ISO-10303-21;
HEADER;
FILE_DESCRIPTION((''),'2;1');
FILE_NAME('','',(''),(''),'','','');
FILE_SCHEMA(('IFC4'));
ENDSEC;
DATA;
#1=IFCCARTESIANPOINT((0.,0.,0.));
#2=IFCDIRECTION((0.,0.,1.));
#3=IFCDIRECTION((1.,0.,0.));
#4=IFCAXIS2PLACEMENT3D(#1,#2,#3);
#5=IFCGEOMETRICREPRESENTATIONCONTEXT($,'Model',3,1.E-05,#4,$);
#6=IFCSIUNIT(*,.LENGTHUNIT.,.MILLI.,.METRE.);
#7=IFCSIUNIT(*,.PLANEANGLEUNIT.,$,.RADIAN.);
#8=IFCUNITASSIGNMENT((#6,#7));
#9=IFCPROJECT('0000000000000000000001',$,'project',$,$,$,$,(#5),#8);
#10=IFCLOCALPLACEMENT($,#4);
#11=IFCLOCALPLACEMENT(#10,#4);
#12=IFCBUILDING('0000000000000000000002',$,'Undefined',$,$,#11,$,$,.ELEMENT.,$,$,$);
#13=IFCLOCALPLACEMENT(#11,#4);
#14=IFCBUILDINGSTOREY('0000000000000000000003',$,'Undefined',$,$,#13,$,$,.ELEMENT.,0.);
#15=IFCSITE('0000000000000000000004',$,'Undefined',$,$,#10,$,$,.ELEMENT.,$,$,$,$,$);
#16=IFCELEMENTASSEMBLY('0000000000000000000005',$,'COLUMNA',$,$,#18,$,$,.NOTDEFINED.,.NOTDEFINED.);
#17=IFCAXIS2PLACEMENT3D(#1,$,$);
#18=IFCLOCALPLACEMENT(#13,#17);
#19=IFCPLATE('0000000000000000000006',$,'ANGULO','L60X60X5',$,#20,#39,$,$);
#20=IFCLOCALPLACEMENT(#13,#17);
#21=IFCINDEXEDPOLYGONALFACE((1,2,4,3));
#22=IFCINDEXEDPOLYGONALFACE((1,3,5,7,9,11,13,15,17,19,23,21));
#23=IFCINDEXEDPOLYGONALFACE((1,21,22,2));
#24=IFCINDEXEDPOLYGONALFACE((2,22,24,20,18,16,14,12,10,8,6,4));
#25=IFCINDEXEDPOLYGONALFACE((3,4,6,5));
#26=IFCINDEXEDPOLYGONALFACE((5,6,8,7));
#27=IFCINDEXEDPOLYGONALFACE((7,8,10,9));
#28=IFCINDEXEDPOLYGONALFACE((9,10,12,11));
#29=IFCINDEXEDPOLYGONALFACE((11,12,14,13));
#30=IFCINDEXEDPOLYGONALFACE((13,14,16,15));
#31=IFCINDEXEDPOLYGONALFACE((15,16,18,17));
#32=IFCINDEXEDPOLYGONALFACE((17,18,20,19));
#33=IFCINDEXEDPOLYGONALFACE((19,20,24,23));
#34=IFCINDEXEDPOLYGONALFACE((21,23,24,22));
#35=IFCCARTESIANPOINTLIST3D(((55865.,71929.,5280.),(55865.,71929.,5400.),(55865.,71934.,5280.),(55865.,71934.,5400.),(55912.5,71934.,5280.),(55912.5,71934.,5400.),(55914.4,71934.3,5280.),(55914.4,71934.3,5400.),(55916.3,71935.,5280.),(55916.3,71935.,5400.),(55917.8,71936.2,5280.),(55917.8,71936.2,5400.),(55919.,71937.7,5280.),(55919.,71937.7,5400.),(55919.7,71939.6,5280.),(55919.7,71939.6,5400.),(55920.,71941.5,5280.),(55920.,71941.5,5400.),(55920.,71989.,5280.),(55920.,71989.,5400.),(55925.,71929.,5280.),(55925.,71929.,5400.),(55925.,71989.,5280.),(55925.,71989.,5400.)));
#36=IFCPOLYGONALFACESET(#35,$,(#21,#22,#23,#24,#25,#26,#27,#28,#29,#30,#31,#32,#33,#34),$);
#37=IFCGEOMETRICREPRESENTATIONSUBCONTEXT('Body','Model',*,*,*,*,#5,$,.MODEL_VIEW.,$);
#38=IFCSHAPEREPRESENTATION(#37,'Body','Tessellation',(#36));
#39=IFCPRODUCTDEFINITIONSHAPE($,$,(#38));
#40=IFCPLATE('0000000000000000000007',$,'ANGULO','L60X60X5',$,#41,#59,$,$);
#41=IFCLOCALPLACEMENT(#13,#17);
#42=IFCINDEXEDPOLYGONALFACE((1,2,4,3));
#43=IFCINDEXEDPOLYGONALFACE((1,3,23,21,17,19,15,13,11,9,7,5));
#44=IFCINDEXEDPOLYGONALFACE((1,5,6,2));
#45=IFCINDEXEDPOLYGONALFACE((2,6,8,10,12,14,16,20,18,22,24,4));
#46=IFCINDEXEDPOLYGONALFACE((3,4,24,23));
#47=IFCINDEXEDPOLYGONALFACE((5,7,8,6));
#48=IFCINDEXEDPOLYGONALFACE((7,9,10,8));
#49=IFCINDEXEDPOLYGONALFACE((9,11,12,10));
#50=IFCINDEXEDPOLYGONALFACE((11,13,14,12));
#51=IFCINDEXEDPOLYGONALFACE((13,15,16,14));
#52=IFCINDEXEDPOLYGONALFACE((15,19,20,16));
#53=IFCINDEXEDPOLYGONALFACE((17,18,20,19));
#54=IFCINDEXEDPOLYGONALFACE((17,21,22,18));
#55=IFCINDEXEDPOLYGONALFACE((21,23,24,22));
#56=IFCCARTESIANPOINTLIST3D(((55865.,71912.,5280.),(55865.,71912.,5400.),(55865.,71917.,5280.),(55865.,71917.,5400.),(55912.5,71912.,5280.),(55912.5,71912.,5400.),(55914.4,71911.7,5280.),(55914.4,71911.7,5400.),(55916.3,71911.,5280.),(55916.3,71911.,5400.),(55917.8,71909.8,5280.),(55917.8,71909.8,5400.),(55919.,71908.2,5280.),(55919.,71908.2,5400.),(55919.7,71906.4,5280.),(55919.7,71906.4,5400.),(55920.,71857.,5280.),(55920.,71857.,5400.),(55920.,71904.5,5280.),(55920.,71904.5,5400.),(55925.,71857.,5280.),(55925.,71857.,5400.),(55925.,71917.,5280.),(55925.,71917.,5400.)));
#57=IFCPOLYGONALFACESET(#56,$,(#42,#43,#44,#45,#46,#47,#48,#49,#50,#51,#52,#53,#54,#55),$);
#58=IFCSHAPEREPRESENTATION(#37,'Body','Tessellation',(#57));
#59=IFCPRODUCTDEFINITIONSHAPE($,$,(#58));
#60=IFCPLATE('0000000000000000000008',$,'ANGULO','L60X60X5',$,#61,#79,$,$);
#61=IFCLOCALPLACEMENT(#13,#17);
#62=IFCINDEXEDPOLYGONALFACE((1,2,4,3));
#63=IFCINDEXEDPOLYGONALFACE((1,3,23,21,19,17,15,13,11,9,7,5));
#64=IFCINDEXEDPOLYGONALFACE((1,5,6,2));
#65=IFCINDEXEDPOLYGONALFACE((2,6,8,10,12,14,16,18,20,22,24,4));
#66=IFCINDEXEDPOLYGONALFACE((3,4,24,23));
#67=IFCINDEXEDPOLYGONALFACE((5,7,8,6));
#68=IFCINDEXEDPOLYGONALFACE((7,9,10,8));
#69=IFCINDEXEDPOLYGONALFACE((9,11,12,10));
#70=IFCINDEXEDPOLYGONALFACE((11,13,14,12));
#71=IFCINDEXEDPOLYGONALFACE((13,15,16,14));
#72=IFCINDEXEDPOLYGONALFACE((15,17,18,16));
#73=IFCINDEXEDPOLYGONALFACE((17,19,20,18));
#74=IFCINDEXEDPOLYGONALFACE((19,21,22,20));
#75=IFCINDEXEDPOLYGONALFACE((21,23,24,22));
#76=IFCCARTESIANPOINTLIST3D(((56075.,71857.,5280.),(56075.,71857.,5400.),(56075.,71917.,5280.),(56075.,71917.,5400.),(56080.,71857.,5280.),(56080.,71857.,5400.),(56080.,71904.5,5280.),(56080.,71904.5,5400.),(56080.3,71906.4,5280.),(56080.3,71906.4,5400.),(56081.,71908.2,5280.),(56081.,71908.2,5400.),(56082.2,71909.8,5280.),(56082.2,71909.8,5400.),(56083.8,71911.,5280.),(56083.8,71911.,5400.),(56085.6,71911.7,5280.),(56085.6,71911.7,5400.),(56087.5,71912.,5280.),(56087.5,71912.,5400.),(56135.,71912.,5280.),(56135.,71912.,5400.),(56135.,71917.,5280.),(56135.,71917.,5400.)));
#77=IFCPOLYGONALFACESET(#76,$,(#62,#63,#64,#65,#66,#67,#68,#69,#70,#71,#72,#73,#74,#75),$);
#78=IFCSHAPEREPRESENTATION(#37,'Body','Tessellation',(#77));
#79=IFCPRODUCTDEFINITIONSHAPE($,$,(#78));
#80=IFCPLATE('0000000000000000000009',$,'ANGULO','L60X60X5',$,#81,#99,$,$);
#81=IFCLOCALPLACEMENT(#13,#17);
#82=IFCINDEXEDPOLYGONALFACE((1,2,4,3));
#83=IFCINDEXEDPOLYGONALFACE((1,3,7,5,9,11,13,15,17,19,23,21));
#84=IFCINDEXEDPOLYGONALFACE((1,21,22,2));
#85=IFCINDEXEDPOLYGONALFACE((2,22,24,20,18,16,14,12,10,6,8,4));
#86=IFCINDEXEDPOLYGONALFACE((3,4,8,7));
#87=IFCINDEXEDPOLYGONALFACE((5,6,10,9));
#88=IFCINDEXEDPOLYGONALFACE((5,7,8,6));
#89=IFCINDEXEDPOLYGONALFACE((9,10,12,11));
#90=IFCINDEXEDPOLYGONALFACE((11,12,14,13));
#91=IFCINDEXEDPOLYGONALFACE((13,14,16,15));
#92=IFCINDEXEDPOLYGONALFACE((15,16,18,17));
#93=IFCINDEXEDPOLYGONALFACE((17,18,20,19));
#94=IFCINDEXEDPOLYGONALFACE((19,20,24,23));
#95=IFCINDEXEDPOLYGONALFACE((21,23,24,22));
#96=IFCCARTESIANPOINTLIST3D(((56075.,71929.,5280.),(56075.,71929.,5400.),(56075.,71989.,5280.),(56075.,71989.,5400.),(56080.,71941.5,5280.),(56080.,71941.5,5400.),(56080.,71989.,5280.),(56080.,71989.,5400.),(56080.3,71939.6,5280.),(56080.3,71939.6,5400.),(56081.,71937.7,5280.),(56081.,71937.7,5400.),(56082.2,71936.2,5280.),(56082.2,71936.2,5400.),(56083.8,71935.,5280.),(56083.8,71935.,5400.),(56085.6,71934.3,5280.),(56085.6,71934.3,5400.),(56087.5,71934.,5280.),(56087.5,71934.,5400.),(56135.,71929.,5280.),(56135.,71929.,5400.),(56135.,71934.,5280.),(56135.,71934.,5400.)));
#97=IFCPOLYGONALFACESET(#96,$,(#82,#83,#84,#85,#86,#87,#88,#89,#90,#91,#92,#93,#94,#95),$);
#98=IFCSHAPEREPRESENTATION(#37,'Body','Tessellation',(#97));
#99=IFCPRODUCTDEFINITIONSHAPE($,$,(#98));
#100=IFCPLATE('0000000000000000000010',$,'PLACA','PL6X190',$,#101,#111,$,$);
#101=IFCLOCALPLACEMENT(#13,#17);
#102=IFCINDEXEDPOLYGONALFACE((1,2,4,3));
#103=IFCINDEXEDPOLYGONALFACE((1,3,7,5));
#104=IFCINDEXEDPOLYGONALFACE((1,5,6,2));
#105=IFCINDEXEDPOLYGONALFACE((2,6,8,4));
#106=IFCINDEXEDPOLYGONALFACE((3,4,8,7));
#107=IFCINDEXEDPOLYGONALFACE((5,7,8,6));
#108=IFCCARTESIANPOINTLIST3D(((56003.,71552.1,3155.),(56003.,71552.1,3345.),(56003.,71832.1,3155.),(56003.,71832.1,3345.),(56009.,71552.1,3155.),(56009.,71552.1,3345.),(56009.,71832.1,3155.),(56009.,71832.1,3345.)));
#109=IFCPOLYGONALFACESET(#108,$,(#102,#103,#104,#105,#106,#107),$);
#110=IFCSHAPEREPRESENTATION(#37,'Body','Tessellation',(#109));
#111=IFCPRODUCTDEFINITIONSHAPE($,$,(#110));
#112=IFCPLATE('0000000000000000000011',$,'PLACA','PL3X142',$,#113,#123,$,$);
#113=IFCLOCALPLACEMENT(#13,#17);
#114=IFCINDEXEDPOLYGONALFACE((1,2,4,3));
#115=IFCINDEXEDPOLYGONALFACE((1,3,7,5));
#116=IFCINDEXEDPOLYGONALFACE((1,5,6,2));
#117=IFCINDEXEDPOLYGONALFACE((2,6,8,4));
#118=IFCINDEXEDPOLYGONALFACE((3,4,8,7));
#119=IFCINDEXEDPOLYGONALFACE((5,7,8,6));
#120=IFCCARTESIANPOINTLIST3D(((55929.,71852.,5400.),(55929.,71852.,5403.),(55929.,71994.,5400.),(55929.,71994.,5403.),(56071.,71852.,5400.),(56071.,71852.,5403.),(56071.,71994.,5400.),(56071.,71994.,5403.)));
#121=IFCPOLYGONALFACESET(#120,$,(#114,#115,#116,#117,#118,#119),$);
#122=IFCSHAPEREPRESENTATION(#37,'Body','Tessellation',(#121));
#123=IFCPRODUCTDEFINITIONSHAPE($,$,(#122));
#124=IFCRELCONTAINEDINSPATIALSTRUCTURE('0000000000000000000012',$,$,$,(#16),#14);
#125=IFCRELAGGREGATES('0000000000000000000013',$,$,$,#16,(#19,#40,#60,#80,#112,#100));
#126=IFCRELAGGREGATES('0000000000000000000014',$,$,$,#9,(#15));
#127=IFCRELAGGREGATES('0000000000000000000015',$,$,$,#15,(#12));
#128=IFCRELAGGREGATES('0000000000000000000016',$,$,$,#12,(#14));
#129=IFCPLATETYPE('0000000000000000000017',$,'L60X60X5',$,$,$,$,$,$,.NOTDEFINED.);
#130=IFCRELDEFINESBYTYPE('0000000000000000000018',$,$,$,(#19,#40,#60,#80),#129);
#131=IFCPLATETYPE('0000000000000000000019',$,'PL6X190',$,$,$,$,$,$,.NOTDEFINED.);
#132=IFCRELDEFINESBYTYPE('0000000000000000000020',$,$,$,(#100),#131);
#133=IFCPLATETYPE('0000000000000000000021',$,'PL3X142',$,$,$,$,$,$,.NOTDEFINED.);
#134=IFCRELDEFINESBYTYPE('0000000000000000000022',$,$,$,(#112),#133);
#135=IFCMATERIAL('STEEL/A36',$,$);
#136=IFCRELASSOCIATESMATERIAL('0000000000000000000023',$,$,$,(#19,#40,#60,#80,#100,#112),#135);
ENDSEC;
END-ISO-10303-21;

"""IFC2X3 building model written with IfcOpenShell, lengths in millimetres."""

from ifc_helpers import new_model, si_unit, frame, origin_with_axes, origin_2d_with_axis, place, context, subcontext, project, spatial, polyline, l_section, outline, extrude, material, type_object, element, aggregate, save


model = new_model("IFC2X3")

# Units and contexts
model_context = context("Model", 3, precision=1e-05, world=origin_with_axes())
body_context = subcontext(model_context, "Body", "Model", "MODEL_VIEW")
ifc_project = project(units=[si_unit("LENGTHUNIT", "METRE", prefix="MILLI"), si_unit("PLANEANGLEUNIT", "RADIAN")], contexts=[model_context])

# Site, building, storey
site_placement = place(None, origin_with_axes())
site = spatial("IfcSite", under=ifc_project, at=site_placement, Name="Undefined", CompositionType="ELEMENT")
building_placement = place(site_placement, origin_with_axes())
building = spatial("IfcBuilding", under=site, at=building_placement, Name="Undefined", CompositionType="ELEMENT")
storey_placement = place(building_placement, origin_with_axes())
storey = spatial("IfcBuildingStorey", under=building, at=storey_placement, Name="Undefined", CompositionType="ELEMENT", Elevation=0.0)

# Element assembly
assembly_1_placement = place(storey_placement, origin_with_axes())
assembly_1 = element("IfcElementAssembly", 1, at=assembly_1_placement, inside=storey, Name="COLUMNA", AssemblyPlace="NOTDEFINED", PredefinedType="NOTDEFINED")
ifc_material_1 = material(Name="STEEL/A36")

# Plates
plate_type_1 = type_object("IfcPlateType", Name="L60X60X5", PredefinedType="NOTDEFINED")
plate_1_placement = place(assembly_1_placement, frame((55895.0, 71959.0, 5280.0), z_axis=(0.0, 1.0, 0.0), x_axis=(0.0, 0.0, 1.0)))
plate_1 = element("IfcPlate", 2, at=plate_1_placement, type_object=plate_type_1, material=ifc_material_1, Name="ANGULO", Description="L60X60X5", context=body_context, shape_type="SweptSolid", body=[
    extrude(l_section(Depth=60.0, Width=60.0, Thickness=5.0, FilletRadius=7.5, at=origin_2d_with_axis()), frame((120.0, 0.0, 0.0), z_axis=(-1.0, 0.0, 0.0), x_axis=(0.0, -1.0, 0.0)), (0.0, 0.0, 1.0), 120.0),
])
plate_2_placement = place(assembly_1_placement, frame((55895.0, 71887.0, 5400.0), z_axis=(0.0, -1.0, 0.0), x_axis=(0.0, 0.0, -1.0)))
plate_2 = element("IfcPlate", 3, at=plate_2_placement, type_object=plate_type_1, material=ifc_material_1, Name="ANGULO", Description="L60X60X5", context=body_context, shape_type="SweptSolid", body=[
    extrude(l_section(Depth=60.0, Width=60.0, Thickness=5.0, FilletRadius=7.5, at=origin_2d_with_axis()), frame((120.0, 0.0, 0.0), z_axis=(-1.0, 0.0, 0.0), x_axis=(0.0, -1.0, 0.0)), (0.0, 0.0, 1.0), 120.0),
])
plate_3_placement = place(assembly_1_placement, frame((56105.0, 71887.0, 5280.0), z_axis=(0.0, -1.0, 0.0), x_axis=(0.0, 0.0, 1.0)))
plate_3 = element("IfcPlate", 4, at=plate_3_placement, type_object=plate_type_1, material=ifc_material_1, Name="ANGULO", Description="L60X60X5", context=body_context, shape_type="SweptSolid", body=[
    extrude(l_section(Depth=60.0, Width=60.0, Thickness=5.0, FilletRadius=7.5, at=origin_2d_with_axis()), frame((120.0, 0.0, 0.0), z_axis=(-1.0, 0.0, 0.0), x_axis=(0.0, -1.0, 0.0)), (0.0, 0.0, 1.0), 120.0),
])
plate_4_placement = place(assembly_1_placement, frame((56105.0, 71959.0, 5400.0), z_axis=(0.0, 1.0, 0.0), x_axis=(0.0, 0.0, -1.0)))
plate_4 = element("IfcPlate", 5, at=plate_4_placement, type_object=plate_type_1, material=ifc_material_1, Name="ANGULO", Description="L60X60X5", context=body_context, shape_type="SweptSolid", body=[
    extrude(l_section(Depth=60.0, Width=60.0, Thickness=5.0, FilletRadius=7.5, at=origin_2d_with_axis()), frame((120.0, 0.0, 0.0), z_axis=(-1.0, 0.0, 0.0), x_axis=(0.0, -1.0, 0.0)), (0.0, 0.0, 1.0), 120.0),
])
plate_type_2 = type_object("IfcPlateType", Name="PL6X190", PredefinedType="NOTDEFINED")
plate_5_placement = place(assembly_1_placement, frame((56006.0, 71552.1, 3250.0), z_axis=(1.0, 0.0, 0.0), x_axis=(0.0, 1.0, 0.0)))
plate_5 = element("IfcPlate", 6, at=plate_5_placement, type_object=plate_type_2, material=ifc_material_1, Name="PLACA", Description="PL6X190", context=body_context, shape_type="SweptSolid", body=[
    extrude(outline(polyline([(0.0, -95.0), (0.0, 95.0), (280.0, 95.0), (280.0, -95.0), (0.0, -95.0)])), frame((0.0, 0.0, -3.0), z_axis=(0.0, 0.0, 1.0), x_axis=(1.0, 0.0, 0.0)), (0.0, 0.0, 1.0), 6.0),
])
plate_type_3 = type_object("IfcPlateType", Name="PL3X142", PredefinedType="NOTDEFINED")
plate_6_placement = place(assembly_1_placement, frame((56071.0, 71994.0, 5401.5), z_axis=(0.0, 0.0, -1.0), x_axis=(0.0, -1.0, 0.0)))
plate_6 = element("IfcPlate", 7, at=plate_6_placement, type_object=plate_type_3, material=ifc_material_1, Name="PLACA", Description="PL3X142", context=body_context, shape_type="SweptSolid", body=[
    extrude(outline(polyline([(0.0, 0.0), (142.0, 0.0), (142.0, 142.0), (0.0, 142.0), (0.0, 0.0)])), frame((0.0, 0.0, -1.5), z_axis=(0.0, 0.0, 1.0), x_axis=(1.0, 0.0, 0.0)), (0.0, 0.0, 1.0), 3.0),
])

aggregate(assembly_1, [plate_1, plate_2, plate_3, plate_4, plate_6, plate_5])

save(model, "model.ifc")
